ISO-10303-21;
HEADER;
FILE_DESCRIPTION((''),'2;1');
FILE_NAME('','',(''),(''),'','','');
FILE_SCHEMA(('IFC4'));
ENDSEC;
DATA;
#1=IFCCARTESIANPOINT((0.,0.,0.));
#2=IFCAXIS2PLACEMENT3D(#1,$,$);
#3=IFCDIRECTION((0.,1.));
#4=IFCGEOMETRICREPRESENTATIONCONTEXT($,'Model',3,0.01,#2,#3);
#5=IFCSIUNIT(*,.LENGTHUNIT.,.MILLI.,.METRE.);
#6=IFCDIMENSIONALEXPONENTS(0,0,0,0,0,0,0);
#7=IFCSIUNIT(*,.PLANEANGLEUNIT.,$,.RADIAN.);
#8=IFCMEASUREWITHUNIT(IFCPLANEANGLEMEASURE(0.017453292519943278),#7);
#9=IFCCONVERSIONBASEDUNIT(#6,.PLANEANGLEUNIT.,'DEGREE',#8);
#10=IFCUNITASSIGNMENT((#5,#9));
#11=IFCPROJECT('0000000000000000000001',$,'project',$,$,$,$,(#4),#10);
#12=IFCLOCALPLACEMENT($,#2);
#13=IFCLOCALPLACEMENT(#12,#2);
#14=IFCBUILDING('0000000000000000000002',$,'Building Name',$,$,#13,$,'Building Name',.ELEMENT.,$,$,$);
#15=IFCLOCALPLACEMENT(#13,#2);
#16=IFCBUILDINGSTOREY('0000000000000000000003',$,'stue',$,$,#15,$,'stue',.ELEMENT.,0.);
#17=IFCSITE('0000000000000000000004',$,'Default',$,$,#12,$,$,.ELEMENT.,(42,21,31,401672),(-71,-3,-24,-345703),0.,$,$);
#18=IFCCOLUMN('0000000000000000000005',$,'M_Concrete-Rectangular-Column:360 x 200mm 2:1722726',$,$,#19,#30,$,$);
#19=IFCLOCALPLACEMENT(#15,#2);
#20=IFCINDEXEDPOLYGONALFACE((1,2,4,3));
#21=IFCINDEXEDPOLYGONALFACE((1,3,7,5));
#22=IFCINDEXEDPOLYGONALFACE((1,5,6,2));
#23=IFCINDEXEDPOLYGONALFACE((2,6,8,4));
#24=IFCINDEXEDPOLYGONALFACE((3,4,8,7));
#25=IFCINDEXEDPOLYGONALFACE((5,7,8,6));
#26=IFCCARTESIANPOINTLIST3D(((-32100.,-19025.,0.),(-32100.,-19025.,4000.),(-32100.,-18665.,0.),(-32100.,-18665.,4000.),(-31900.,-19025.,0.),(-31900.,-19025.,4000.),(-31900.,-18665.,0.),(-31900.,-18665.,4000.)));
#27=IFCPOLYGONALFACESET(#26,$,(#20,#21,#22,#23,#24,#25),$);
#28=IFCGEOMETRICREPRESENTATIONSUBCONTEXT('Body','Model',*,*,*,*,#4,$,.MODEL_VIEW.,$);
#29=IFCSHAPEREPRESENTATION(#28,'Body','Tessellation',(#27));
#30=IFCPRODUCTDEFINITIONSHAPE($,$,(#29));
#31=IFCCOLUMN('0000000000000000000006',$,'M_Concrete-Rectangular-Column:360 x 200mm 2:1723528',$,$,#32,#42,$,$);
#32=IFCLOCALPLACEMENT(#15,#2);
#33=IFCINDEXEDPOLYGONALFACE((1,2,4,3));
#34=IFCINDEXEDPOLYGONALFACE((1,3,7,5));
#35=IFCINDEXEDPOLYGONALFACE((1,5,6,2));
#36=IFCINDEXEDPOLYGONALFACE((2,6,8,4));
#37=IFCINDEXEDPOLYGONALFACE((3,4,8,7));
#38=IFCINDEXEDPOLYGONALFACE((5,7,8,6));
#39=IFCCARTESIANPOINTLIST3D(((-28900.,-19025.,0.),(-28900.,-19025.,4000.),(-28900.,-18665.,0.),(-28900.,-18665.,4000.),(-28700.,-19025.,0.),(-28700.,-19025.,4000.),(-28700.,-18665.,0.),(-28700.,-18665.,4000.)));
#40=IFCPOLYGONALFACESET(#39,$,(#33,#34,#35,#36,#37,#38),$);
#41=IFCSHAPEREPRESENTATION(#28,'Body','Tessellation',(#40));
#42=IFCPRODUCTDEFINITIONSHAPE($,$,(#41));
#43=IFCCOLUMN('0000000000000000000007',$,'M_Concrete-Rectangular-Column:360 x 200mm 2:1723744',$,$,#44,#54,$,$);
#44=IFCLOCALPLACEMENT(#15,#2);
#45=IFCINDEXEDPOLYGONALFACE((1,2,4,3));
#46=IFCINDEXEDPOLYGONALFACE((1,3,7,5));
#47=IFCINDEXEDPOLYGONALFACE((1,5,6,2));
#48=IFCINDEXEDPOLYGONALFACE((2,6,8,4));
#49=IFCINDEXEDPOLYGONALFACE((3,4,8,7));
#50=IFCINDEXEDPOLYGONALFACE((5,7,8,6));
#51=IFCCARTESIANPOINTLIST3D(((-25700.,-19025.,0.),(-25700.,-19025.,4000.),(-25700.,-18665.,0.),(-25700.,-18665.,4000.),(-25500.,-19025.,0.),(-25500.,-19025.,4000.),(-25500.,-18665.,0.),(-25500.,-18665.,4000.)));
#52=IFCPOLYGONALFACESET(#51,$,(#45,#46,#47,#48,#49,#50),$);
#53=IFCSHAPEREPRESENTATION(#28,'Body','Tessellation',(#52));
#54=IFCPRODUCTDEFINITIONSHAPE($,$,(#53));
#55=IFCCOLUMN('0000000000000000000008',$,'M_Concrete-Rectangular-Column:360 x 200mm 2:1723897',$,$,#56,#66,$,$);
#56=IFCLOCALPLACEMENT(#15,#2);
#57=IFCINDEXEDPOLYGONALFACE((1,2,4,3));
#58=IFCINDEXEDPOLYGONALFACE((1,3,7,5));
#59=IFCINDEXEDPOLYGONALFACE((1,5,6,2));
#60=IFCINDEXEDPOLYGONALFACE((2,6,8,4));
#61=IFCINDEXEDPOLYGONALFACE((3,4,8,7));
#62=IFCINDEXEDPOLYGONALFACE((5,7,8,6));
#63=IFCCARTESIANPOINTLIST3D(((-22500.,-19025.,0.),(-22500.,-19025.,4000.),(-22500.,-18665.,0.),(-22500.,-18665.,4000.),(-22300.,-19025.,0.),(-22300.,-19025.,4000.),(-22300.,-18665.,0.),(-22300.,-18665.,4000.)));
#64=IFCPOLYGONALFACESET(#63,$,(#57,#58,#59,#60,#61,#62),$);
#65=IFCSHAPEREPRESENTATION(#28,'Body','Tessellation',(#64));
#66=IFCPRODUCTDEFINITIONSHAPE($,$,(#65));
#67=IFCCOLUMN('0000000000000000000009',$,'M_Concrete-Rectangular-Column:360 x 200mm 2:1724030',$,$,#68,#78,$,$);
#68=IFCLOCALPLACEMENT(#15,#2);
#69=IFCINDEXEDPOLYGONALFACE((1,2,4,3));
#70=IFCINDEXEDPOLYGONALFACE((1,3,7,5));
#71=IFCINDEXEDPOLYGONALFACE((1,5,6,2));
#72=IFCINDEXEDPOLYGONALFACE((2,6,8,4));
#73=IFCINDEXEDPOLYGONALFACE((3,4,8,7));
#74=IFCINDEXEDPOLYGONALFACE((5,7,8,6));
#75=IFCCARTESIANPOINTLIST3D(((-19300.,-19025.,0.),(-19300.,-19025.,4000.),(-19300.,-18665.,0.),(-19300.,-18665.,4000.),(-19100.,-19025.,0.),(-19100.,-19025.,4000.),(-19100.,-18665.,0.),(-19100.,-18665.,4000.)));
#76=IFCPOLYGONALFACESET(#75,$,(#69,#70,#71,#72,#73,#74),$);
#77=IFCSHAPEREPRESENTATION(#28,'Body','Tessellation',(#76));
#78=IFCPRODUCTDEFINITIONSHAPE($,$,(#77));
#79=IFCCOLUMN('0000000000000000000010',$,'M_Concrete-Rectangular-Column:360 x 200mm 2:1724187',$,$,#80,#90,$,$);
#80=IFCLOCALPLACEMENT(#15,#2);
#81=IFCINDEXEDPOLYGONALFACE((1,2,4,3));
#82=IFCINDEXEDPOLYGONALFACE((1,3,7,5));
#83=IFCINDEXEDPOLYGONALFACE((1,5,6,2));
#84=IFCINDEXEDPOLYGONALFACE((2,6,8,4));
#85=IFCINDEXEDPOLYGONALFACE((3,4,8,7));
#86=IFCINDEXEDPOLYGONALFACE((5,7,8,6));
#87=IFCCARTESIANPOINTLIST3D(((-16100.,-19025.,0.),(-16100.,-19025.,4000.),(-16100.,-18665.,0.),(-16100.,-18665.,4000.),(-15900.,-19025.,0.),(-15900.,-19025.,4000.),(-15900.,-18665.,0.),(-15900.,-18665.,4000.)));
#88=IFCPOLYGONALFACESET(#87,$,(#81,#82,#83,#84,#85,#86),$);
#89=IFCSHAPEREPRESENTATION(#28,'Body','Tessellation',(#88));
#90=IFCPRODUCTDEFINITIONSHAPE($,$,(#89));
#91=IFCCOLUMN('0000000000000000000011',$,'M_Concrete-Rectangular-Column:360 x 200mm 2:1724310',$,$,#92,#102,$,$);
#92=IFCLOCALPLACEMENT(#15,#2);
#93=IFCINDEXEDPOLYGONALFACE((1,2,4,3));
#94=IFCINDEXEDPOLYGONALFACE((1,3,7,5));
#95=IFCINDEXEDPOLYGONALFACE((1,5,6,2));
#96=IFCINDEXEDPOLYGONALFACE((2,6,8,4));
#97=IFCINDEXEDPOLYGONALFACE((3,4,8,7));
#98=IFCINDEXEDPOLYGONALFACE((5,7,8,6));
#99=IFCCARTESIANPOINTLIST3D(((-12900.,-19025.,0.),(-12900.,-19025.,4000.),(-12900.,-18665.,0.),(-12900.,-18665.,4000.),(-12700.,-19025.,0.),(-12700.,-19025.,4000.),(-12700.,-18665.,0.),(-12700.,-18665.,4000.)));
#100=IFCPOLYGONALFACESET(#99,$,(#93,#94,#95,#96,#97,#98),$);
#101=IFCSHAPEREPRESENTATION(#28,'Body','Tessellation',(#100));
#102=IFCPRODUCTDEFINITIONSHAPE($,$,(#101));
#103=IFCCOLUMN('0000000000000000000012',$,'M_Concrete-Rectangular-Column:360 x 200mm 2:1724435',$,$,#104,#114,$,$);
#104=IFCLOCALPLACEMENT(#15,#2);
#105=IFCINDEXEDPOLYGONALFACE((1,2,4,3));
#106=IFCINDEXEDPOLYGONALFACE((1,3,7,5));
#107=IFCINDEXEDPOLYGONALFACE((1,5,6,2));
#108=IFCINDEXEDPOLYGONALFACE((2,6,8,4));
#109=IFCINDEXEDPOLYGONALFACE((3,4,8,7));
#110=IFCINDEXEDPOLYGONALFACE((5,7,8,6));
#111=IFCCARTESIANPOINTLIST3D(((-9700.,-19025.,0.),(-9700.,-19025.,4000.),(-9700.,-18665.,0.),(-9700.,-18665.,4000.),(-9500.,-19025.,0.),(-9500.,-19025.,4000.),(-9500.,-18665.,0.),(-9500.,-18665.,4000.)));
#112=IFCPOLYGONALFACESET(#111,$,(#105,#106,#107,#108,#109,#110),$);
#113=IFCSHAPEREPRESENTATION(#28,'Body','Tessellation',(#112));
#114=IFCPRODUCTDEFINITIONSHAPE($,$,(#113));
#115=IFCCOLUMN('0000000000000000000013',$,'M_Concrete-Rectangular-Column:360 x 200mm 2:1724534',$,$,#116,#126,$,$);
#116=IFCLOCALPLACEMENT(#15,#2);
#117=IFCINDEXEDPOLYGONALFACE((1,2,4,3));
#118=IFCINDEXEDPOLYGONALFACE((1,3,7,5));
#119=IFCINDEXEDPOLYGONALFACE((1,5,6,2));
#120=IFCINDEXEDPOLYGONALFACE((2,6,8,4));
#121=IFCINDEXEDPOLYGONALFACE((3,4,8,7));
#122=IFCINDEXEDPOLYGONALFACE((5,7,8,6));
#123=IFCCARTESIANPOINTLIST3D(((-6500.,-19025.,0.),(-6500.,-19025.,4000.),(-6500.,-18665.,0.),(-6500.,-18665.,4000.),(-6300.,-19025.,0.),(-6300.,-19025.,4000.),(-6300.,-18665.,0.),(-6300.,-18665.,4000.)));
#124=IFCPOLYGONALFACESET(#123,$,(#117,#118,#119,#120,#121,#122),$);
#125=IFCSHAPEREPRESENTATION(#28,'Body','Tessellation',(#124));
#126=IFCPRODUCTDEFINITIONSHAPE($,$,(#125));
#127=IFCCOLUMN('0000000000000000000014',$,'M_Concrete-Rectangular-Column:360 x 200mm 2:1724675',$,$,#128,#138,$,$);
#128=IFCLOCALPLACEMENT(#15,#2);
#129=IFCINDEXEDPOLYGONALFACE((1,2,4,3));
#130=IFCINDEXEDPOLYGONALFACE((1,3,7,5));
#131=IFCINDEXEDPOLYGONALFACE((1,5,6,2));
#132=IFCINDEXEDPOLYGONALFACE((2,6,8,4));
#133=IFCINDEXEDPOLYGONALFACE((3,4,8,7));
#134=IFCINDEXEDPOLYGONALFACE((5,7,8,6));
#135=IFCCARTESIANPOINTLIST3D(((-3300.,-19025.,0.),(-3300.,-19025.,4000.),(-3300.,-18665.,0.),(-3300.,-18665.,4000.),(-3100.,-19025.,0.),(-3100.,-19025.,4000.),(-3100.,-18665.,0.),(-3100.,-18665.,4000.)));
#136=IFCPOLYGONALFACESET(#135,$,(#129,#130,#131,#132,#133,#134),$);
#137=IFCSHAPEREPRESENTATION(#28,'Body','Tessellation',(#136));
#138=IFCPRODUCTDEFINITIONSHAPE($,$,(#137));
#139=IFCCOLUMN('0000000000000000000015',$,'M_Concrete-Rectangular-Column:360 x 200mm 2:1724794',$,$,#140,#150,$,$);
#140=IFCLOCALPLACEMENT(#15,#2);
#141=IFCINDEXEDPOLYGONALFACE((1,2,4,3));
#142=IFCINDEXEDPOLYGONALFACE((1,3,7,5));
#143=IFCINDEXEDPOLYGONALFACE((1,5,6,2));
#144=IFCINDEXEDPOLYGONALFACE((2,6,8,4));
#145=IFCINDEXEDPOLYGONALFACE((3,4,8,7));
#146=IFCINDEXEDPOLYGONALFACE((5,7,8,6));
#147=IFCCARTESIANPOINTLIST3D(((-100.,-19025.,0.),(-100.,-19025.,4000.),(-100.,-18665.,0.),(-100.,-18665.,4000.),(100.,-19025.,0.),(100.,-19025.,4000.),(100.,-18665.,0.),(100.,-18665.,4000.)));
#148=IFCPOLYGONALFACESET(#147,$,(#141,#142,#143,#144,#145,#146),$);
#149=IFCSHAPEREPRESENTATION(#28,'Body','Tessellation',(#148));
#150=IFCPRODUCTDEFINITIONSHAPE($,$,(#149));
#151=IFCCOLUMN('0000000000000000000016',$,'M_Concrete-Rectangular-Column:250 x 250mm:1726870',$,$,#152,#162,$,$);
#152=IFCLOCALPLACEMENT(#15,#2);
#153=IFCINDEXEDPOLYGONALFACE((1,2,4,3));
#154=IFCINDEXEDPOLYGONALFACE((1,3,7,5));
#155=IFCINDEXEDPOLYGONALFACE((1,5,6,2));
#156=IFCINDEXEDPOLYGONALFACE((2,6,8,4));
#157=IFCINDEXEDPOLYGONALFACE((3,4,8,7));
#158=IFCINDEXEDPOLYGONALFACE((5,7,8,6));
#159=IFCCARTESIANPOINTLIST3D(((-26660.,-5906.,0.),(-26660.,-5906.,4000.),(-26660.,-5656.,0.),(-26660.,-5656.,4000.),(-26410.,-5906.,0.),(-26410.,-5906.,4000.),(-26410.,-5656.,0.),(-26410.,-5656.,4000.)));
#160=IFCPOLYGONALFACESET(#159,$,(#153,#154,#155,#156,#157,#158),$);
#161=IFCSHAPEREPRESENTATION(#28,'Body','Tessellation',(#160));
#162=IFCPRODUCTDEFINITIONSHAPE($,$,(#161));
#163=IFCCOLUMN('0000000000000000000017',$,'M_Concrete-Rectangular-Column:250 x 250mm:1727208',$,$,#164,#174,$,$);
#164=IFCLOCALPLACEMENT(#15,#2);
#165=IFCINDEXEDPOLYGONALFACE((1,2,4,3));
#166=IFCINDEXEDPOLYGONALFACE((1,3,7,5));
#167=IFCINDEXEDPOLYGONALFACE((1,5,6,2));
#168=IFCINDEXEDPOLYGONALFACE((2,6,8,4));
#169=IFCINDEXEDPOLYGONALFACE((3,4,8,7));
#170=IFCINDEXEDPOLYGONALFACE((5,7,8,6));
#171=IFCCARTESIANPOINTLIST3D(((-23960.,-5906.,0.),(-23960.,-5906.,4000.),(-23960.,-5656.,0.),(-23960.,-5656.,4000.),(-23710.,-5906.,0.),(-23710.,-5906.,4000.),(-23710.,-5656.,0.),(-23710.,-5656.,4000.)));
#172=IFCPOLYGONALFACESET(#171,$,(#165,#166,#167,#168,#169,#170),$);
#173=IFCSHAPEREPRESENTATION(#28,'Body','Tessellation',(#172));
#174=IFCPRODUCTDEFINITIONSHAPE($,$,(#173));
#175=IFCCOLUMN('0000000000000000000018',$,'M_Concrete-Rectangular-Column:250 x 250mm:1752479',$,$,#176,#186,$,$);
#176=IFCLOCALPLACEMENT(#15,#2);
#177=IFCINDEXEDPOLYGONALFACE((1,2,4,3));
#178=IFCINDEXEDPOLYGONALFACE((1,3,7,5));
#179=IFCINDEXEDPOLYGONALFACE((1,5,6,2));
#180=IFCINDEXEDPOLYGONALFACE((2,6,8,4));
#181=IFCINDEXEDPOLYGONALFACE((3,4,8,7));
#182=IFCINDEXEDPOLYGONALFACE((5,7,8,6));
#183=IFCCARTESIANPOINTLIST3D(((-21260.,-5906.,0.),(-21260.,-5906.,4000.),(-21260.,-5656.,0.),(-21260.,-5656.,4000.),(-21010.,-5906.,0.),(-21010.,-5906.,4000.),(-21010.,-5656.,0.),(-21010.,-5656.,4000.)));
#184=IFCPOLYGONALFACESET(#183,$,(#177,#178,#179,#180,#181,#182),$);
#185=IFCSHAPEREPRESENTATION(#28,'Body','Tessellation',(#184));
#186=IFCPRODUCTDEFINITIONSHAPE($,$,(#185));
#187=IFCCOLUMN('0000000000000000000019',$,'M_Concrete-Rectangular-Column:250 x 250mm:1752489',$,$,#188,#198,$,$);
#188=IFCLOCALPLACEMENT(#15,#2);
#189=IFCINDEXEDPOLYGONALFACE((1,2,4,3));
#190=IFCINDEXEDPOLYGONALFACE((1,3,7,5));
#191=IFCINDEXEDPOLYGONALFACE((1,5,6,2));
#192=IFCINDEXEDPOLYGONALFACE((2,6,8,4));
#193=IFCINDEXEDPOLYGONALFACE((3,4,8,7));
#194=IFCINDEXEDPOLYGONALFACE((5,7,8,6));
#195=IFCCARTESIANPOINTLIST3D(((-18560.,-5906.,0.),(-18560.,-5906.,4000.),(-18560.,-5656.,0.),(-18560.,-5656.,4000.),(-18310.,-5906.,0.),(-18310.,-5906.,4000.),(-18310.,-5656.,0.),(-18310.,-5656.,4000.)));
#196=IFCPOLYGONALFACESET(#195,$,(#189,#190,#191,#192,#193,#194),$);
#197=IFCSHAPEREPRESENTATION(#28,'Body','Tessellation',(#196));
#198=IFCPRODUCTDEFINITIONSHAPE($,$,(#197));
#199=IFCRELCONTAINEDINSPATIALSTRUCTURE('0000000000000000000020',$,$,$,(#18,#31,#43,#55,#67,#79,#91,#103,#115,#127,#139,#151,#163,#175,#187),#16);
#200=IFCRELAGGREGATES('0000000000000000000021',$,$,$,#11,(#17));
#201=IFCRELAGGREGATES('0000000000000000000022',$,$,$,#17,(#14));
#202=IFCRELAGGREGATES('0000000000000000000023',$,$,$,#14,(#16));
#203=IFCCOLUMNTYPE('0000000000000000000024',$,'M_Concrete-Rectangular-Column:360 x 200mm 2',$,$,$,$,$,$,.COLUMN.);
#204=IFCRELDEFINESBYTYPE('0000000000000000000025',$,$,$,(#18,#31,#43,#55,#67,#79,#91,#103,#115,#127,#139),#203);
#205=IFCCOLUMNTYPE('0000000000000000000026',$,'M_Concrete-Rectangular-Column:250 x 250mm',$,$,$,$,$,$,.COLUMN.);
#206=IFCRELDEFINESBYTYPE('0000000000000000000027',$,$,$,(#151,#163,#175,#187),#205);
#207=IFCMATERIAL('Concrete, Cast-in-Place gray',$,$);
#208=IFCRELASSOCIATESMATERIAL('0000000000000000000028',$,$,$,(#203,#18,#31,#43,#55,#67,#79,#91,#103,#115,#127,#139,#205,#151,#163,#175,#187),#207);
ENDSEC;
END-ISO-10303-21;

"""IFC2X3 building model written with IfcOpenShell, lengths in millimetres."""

from ifc_helpers import new_model, entity, si_unit, converted_unit, direction, frame, origin, origin_2d_with_axis, place, context, subcontext, project, spatial, rectangle, extrude, source, transform, mapped, material, type_object, type_shapes, element, save


model = new_model("IFC2X3")

# Units and contexts
model_context = context("Model", 3, precision=0.01, world=origin(), true_north=direction((0.0, 1.0)))
body_context = subcontext(model_context, "Body", "Model", "MODEL_VIEW")
ifc_project = project(units=[si_unit("LENGTHUNIT", "METRE", prefix="MILLI"), converted_unit("PLANEANGLEUNIT", "DEGREE", entity("IfcPlaneAngleMeasure", 0.017453292519943278), si_unit("PLANEANGLEUNIT", "RADIAN"), dimensions=[0, 0, 0, 0, 0, 0, 0])], contexts=[model_context])

# Site, building, storey
site_placement = place(None, origin())
site = spatial("IfcSite", under=ifc_project, at=site_placement, Name="Default", CompositionType="ELEMENT", RefLatitude=(42, 21, 31, 401672), RefLongitude=(-71, -3, -24, -345703), RefElevation=0.0)
building_placement = place(site_placement, origin())
building = spatial("IfcBuilding", under=site, at=building_placement, Name="Building Name", LongName="Building Name", CompositionType="ELEMENT")
storey_placement = place(building_placement, origin())
storey = spatial("IfcBuildingStorey", under=building, at=storey_placement, Name="stue", LongName="stue", CompositionType="ELEMENT", Elevation=0.0)

# Columns
ifc_material_1 = material(Name="Concrete, Cast-in-Place gray")
column_type_1 = type_object("IfcColumnType", Name="M_Concrete-Rectangular-Column:360 x 200mm 2", PredefinedType="COLUMN", material=ifc_material_1)
shared_shape_1 = source(origin(), body_context, "Body", "SweptSolid", [
    extrude(rectangle(XDim=200.0, YDim=360.0, at=origin_2d_with_axis()), frame((0.0, 0.0, 0.0), z_axis=(0.0, 0.0, 1.0), x_axis=(-1.0, 0.0, 0.0)), (0.0, 0.0, 1.0), 4000.0),
])
type_shapes(column_type_1, [shared_shape_1])
for number, where, name in (
    (1, (-32000.0, -18845.0, 0.0), "M_Concrete-Rectangular-Column:360 x 200mm 2:1722726"),
    (2, (-28800.0, -18845.0, 0.0), "M_Concrete-Rectangular-Column:360 x 200mm 2:1723528"),
    (3, (-25600.0, -18845.0, 0.0), "M_Concrete-Rectangular-Column:360 x 200mm 2:1723744"),
    (4, (-22400.0, -18845.0, 0.0), "M_Concrete-Rectangular-Column:360 x 200mm 2:1723897"),
    (5, (-19200.0, -18845.0, 0.0), "M_Concrete-Rectangular-Column:360 x 200mm 2:1724030"),
    (6, (-16000.0, -18845.0, 0.0), "M_Concrete-Rectangular-Column:360 x 200mm 2:1724187"),
    (7, (-12800.0, -18845.0, 0.0), "M_Concrete-Rectangular-Column:360 x 200mm 2:1724310"),
    (8, (-9600.0, -18845.0, 0.0), "M_Concrete-Rectangular-Column:360 x 200mm 2:1724435"),
    (9, (-6400.0, -18845.0, 0.0), "M_Concrete-Rectangular-Column:360 x 200mm 2:1724534"),
    (10, (-3200.0, -18845.0, 0.0), "M_Concrete-Rectangular-Column:360 x 200mm 2:1724675"),
    (11, (0.0, -18845.0, 0.0), "M_Concrete-Rectangular-Column:360 x 200mm 2:1724794"),
):
    element("IfcColumn", number, at=place(storey_placement, frame(where)), inside=storey, type_object=column_type_1, material=ifc_material_1, Name=name, context=body_context, shape_type="MappedRepresentation", body=[
        mapped(shared_shape_1, transform((0.0, 0.0, 0.0), scale=1.0)),
    ])
column_type_2 = type_object("IfcColumnType", Name="M_Concrete-Rectangular-Column:250 x 250mm", PredefinedType="COLUMN", material=ifc_material_1)
shared_shape_2 = source(origin(), body_context, "Body", "SweptSolid", [
    extrude(rectangle(XDim=250.0, YDim=250.0, at=origin_2d_with_axis()), frame((0.0, 0.0, 0.0), z_axis=(0.0, 0.0, 1.0), x_axis=(-1.0, 0.0, 0.0)), (0.0, 0.0, 1.0), 4000.0),
])
type_shapes(column_type_2, [shared_shape_2])
for number, where, name in (
    (12, (-26535.0, -5781.0, 0.0), "M_Concrete-Rectangular-Column:250 x 250mm:1726870"),
    (13, (-23835.0, -5781.0, 0.0), "M_Concrete-Rectangular-Column:250 x 250mm:1727208"),
    (14, (-21135.0, -5781.0, 0.0), "M_Concrete-Rectangular-Column:250 x 250mm:1752479"),
    (15, (-18435.0, -5781.0, 0.0), "M_Concrete-Rectangular-Column:250 x 250mm:1752489"),
):
    element("IfcColumn", number, at=place(storey_placement, frame(where)), inside=storey, type_object=column_type_2, material=ifc_material_1, Name=name, context=body_context, shape_type="MappedRepresentation", body=[
        mapped(shared_shape_2, transform((0.0, 0.0, 0.0), scale=1.0)),
    ])

save(model, "model.ifc")
